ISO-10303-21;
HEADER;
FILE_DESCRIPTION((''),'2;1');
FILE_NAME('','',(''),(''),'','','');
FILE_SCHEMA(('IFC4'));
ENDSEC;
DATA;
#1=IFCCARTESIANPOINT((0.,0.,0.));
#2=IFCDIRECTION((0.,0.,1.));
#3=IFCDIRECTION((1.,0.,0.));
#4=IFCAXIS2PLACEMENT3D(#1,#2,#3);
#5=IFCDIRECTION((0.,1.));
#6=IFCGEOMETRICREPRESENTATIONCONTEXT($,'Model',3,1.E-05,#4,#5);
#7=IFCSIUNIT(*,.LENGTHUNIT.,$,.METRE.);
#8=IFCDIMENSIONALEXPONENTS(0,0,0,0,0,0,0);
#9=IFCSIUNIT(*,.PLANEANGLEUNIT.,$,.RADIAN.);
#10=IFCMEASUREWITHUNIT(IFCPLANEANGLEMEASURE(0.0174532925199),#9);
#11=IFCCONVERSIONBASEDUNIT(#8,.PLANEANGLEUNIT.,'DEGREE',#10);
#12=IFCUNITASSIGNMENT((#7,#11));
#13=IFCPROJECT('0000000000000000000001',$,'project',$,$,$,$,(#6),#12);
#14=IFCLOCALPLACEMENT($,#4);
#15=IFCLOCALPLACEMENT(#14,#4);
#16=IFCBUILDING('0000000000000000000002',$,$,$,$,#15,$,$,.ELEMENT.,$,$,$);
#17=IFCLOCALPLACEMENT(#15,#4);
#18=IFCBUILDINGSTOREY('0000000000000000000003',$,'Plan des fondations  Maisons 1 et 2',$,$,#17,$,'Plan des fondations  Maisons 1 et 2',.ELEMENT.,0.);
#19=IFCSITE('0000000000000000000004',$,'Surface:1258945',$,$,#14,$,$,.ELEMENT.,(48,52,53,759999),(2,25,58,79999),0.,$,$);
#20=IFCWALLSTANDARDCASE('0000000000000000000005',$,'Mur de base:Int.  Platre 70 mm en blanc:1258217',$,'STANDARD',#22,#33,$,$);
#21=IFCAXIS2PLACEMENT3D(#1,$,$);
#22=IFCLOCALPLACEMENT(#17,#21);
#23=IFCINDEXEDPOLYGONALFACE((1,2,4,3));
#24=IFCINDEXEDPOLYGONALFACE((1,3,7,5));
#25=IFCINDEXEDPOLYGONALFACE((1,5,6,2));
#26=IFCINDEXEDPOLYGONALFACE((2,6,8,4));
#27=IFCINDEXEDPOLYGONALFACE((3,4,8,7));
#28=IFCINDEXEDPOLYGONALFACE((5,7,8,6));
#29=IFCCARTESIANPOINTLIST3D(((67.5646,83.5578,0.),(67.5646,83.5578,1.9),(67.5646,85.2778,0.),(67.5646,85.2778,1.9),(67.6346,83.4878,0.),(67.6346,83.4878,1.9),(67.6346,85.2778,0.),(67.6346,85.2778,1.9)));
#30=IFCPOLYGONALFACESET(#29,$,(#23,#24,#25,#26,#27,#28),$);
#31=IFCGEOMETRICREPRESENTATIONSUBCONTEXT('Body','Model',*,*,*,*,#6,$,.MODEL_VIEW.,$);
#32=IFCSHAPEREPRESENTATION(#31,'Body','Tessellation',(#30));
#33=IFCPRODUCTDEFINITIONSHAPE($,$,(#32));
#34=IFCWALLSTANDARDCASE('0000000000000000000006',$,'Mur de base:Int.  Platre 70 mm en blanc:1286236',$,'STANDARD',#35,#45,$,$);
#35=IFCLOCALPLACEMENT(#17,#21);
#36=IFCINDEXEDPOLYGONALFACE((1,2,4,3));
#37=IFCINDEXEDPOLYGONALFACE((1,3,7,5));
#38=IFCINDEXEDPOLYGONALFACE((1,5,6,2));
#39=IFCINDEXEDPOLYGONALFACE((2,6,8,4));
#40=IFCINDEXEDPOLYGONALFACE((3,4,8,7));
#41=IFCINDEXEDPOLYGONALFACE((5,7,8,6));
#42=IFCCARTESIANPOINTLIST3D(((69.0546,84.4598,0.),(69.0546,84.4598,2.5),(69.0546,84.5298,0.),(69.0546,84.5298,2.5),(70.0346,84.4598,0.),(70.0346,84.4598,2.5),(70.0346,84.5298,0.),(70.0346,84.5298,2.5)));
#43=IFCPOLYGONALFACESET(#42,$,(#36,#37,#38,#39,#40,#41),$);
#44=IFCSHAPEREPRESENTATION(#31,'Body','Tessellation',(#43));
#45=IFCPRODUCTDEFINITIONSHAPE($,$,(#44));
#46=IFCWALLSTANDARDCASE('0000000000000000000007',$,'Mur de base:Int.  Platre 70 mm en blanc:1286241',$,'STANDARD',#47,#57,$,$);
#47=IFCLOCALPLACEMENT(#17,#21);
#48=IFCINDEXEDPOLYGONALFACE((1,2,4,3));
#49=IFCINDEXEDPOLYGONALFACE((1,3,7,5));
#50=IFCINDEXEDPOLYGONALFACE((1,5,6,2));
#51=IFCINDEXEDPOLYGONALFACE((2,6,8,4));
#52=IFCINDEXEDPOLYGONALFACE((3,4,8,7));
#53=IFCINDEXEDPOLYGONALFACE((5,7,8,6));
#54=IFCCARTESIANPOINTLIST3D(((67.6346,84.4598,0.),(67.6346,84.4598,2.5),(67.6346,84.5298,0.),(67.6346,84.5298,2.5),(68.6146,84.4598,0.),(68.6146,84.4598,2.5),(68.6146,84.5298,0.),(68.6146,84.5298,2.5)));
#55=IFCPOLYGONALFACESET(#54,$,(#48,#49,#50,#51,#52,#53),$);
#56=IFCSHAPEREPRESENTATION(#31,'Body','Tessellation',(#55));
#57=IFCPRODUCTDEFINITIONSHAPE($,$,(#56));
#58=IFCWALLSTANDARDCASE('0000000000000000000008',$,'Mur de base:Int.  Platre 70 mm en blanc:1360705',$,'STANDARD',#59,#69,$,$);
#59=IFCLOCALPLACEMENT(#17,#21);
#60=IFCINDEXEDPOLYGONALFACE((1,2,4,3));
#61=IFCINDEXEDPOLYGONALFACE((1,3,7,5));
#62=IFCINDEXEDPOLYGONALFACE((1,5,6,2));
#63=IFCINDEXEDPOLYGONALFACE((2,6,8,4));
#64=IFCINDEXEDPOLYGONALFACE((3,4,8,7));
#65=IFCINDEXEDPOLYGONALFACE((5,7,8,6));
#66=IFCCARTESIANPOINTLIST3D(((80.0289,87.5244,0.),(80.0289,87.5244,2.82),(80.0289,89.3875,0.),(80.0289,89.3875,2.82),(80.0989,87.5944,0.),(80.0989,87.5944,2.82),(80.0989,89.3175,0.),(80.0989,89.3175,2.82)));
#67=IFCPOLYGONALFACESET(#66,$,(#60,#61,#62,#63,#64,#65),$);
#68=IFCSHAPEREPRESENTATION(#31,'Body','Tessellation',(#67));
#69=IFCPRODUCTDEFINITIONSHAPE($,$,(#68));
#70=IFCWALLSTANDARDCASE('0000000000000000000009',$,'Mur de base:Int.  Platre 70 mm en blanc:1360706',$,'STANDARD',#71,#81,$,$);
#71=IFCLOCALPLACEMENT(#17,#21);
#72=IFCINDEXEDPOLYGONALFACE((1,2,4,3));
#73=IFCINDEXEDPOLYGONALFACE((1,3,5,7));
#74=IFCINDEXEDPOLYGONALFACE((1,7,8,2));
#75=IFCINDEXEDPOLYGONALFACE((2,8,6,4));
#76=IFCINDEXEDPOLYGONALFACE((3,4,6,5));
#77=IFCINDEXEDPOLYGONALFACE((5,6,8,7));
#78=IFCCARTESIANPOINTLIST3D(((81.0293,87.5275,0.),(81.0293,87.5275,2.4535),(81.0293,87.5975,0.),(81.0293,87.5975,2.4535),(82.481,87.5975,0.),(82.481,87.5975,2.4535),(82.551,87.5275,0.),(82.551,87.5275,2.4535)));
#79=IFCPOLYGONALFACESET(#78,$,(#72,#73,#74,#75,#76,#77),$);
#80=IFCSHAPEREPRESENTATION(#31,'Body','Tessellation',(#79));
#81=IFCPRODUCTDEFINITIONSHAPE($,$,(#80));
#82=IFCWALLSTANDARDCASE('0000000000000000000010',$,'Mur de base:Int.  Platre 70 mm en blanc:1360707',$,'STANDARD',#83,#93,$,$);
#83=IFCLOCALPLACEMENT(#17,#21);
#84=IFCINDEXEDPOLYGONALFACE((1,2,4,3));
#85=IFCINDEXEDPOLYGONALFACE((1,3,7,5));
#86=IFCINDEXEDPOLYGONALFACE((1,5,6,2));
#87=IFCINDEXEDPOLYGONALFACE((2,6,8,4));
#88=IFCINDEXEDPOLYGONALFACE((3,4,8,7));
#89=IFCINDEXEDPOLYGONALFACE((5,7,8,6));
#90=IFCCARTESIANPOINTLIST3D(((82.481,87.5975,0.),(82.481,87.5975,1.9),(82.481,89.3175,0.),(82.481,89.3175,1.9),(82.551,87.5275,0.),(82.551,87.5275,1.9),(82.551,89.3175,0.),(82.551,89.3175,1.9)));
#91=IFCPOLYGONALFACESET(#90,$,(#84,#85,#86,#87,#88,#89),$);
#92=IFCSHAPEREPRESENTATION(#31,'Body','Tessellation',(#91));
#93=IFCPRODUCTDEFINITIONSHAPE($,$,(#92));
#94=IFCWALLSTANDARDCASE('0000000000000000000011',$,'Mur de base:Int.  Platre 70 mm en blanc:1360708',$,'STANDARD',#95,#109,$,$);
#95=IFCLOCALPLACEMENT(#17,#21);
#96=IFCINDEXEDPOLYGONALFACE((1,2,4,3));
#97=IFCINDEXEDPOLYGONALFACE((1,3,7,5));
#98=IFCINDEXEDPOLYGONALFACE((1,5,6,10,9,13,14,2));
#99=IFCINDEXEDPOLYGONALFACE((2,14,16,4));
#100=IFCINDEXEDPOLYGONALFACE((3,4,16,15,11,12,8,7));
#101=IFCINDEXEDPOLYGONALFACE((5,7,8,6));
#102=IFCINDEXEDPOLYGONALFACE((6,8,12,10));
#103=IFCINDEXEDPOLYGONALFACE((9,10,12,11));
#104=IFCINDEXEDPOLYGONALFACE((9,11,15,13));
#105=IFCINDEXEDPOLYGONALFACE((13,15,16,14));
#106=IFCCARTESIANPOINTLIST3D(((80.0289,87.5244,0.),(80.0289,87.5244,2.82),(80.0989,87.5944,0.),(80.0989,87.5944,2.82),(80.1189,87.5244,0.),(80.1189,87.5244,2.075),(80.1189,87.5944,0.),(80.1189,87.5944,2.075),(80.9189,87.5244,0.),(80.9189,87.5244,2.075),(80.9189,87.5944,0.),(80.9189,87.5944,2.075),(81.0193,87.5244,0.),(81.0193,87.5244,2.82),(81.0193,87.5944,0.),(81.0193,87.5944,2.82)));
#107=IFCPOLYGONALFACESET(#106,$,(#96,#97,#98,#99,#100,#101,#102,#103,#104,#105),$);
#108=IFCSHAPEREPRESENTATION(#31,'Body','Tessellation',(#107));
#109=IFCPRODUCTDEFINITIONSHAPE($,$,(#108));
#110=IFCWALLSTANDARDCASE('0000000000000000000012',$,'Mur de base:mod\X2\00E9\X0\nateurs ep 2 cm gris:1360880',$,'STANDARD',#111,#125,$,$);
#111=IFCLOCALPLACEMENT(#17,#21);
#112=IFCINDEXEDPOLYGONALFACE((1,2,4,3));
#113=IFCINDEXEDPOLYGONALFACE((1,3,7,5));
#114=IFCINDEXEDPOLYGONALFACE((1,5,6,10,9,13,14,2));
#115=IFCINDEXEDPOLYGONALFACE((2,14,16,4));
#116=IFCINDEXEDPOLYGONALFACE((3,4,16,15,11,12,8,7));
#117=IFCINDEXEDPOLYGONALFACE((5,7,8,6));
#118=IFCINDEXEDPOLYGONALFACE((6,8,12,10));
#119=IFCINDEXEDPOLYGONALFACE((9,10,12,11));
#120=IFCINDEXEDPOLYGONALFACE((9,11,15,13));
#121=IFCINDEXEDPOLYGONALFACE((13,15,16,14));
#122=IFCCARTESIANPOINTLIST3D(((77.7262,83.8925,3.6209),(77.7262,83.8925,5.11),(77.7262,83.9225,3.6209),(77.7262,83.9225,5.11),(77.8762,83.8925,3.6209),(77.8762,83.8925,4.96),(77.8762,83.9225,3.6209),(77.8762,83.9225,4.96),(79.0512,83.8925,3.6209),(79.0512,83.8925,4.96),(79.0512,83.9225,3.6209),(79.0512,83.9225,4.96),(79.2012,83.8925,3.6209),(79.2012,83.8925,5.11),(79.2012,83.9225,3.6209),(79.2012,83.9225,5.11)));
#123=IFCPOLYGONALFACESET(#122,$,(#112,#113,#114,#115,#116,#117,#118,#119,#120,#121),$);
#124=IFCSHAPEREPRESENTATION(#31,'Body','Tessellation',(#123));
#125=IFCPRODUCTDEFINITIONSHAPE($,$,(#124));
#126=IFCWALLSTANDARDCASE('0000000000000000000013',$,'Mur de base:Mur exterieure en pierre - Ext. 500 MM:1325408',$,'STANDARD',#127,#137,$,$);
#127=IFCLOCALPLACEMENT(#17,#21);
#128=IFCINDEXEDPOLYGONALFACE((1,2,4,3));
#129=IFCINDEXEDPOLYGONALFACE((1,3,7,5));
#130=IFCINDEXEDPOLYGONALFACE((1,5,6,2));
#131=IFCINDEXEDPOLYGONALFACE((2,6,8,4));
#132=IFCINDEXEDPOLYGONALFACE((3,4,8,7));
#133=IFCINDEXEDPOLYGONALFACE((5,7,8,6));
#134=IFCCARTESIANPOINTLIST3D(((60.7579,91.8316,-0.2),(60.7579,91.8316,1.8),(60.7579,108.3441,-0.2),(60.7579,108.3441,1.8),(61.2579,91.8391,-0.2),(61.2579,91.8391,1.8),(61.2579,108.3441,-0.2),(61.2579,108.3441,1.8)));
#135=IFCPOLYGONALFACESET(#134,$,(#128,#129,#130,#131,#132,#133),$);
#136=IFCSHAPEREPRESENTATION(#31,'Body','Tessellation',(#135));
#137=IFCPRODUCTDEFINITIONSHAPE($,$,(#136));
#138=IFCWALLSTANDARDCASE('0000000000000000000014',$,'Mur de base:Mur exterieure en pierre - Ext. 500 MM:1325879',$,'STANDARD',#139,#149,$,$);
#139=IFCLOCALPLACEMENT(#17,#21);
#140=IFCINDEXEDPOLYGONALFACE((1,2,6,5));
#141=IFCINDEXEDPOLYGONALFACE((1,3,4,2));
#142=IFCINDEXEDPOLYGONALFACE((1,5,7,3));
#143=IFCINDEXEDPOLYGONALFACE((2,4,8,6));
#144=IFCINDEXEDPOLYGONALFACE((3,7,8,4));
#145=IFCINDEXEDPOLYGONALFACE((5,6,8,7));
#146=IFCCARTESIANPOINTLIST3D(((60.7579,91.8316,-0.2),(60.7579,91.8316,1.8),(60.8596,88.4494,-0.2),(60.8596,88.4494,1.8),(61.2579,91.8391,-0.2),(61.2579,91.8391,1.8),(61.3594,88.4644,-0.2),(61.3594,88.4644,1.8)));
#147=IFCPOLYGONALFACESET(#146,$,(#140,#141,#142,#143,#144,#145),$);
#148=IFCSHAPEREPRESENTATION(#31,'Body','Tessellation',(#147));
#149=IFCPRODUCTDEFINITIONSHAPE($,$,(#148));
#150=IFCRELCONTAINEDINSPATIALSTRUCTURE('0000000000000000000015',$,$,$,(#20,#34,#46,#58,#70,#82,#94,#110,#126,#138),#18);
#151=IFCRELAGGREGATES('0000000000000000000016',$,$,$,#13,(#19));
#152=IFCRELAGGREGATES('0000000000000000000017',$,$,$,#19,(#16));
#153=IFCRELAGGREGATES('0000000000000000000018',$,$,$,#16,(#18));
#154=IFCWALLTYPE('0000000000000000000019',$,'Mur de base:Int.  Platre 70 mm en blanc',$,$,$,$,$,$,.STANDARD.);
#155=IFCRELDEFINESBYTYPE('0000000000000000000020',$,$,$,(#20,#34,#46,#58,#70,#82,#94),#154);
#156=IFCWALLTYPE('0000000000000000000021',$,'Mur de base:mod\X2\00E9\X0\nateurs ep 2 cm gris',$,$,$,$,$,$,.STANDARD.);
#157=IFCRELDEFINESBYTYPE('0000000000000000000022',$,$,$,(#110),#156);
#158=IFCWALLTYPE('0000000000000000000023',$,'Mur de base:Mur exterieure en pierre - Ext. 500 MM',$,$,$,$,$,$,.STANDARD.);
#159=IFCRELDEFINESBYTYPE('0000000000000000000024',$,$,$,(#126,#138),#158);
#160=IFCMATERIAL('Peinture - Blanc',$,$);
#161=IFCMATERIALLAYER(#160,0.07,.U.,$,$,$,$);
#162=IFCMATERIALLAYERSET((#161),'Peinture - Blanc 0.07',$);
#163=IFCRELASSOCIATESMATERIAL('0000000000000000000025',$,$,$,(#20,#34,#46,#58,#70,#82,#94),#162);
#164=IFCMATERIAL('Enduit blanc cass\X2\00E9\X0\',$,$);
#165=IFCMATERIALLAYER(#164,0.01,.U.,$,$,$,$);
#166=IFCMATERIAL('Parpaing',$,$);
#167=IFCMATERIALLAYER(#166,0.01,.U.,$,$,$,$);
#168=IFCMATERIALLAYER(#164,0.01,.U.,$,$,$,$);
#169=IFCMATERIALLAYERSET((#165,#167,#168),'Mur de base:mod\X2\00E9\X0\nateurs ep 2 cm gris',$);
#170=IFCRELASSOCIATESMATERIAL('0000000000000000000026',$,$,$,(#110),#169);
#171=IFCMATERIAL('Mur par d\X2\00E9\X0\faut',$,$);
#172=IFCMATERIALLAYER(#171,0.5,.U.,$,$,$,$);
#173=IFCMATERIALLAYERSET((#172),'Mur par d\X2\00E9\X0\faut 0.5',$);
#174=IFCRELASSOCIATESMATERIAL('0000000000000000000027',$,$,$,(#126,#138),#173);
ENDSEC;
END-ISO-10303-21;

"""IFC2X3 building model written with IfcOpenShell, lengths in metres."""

from ifc_helpers import new_model, entity, si_unit, converted_unit, direction, frame, origin_with_axes, origin_2d_with_axis, place, context, subcontext, project, spatial, polyline, rectangle, outline, extrude, clip, halfspace, material, layer, layer_set, layer_usage, type_object, element, save


model = new_model("IFC2X3")

# Units and contexts
model_context = context("Model", 3, precision=1e-05, world=origin_with_axes(), true_north=direction((0.0, 1.0)))
body_context = subcontext(model_context, "Body", "Model", "MODEL_VIEW")
ifc_project = project(units=[si_unit("LENGTHUNIT", "METRE"), converted_unit("PLANEANGLEUNIT", "DEGREE", entity("IfcPlaneAngleMeasure", 0.0174532925199), si_unit("PLANEANGLEUNIT", "RADIAN"), dimensions=[0, 0, 0, 0, 0, 0, 0])], contexts=[model_context])

# Site, building, storey
site_placement = place(None, origin_with_axes())
site = spatial("IfcSite", under=ifc_project, at=site_placement, Name="Surface:1258945", CompositionType="ELEMENT", RefLatitude=(48, 52, 53, 759999), RefLongitude=(2, 25, 58, 79999), RefElevation=0.0)
building_placement = place(site_placement, origin_with_axes())
building = spatial("IfcBuilding", under=site, at=building_placement, CompositionType="ELEMENT")
storey_placement = place(building_placement, origin_with_axes())
storey = spatial("IfcBuildingStorey", under=building, at=storey_placement, Name="Plan des fondations  Maisons 1 et 2", LongName="Plan des fondations  Maisons 1 et 2", CompositionType="ELEMENT", Elevation=0.0)

# Shared definitions
ifc_material_1 = material(Name="Parpaing")
ifc_material_2 = material(Name="Peinture - Blanc")

# Walls
ifc_layer_1 = layer(ifc_material_2, 0.07, ventilated="UNKNOWN")
ifc_layer_set_1 = layer_set([ifc_layer_1], Name="Peinture - Blanc 0.07")
wall_type_1 = type_object("IfcWallType", Name="Mur de base:Int.  Platre 70 mm en blanc", PredefinedType="STANDARD")
ifc_layer_usage_1 = layer_usage(ifc_layer_set_1, "AXIS2", "POSITIVE", -0.035)
wall_1_placement = place(storey_placement, frame((67.5996, 83.5228, 0.0), z_axis=(0.0, 0.0, 1.0), x_axis=(0.0, 1.0, 0.0)))
element("IfcWallStandardCase", 1, at=wall_1_placement, inside=storey, type_object=wall_type_1, material=ifc_layer_usage_1, Name="Mur de base:Int.  Platre 70 mm en blanc:1258217", ObjectType="STANDARD", context=body_context, shape_type="SweptSolid", body=[
    extrude(outline(polyline([(-0.035, -0.035), (1.755, -0.035), (1.755, 0.035), (0.035, 0.035), (-0.035, -0.035)])), origin_with_axes(), (0.0, 0.0, 1.0), 1.9),
])
ifc_layer_usage_2 = layer_usage(ifc_layer_set_1, "AXIS2", "POSITIVE", -0.035)
wall_2_placement = place(storey_placement, frame((70.0696, 84.4948, 0.0), z_axis=(0.0, 0.0, 1.0), x_axis=(-1.0, 0.0, 0.0)))
element("IfcWallStandardCase", 2, at=wall_2_placement, inside=storey, type_object=wall_type_1, material=ifc_layer_usage_2, Name="Mur de base:Int.  Platre 70 mm en blanc:1286236", ObjectType="STANDARD", context=body_context, shape_type="SweptSolid", body=[
    extrude(outline(polyline([(0.035, -0.035), (1.015, -0.035), (1.015, 0.035), (0.035, 0.035), (0.035, -0.035)])), origin_with_axes(), (0.0, 0.0, 1.0), 2.5),
])
ifc_layer_usage_3 = layer_usage(ifc_layer_set_1, "AXIS2", "POSITIVE", -0.035)
wall_3_placement = place(storey_placement, frame((67.5996, 84.4948, 0.0), z_axis=(0.0, 0.0, 1.0), x_axis=(1.0, 0.0, 0.0)))
element("IfcWallStandardCase", 3, at=wall_3_placement, inside=storey, type_object=wall_type_1, material=ifc_layer_usage_3, Name="Mur de base:Int.  Platre 70 mm en blanc:1286241", ObjectType="STANDARD", context=body_context, shape_type="SweptSolid", body=[
    extrude(outline(polyline([(0.035, -0.035), (1.015, -0.035), (1.015, 0.035), (0.035, 0.035), (0.035, -0.035)])), origin_with_axes(), (0.0, 0.0, 1.0), 2.5),
])
ifc_layer_usage_4 = layer_usage(ifc_layer_set_1, "AXIS2", "POSITIVE", -0.035)
wall_4_placement = place(storey_placement, frame((80.0639, 87.5594, 0.0), z_axis=(0.0, 0.0, 1.0), x_axis=(0.0, 1.0, 0.0)))
element("IfcWallStandardCase", 4, at=wall_4_placement, inside=storey, type_object=wall_type_1, material=ifc_layer_usage_4, Name="Mur de base:Int.  Platre 70 mm en blanc:1360705", ObjectType="STANDARD", context=body_context, shape_type="SweptSolid", body=[
    extrude(outline(polyline([(0.035, -0.035), (1.7581, -0.035), (1.8281, 0.035), (-0.035, 0.035), (0.035, -0.035)])), origin_with_axes(), (0.0, 0.0, 1.0), 2.82),
])
ifc_layer_usage_5 = layer_usage(ifc_layer_set_1, "AXIS2", "POSITIVE", -0.035)
wall_5_placement = place(storey_placement, frame((82.516, 87.5625, 0.0), z_axis=(0.0, 0.0, 1.0), x_axis=(-1.0, 0.0, 0.0)))
element("IfcWallStandardCase", 5, at=wall_5_placement, inside=storey, type_object=wall_type_1, material=ifc_layer_usage_5, Name="Mur de base:Int.  Platre 70 mm en blanc:1360706", ObjectType="STANDARD", context=body_context, shape_type="SweptSolid", body=[
    extrude(outline(polyline([(0.035, -0.035), (1.4867, -0.035), (1.4867, 0.035), (-0.035, 0.035), (0.035, -0.035)])), origin_with_axes(), (0.0, 0.0, 1.0), 2.4535),
])
ifc_layer_usage_6 = layer_usage(ifc_layer_set_1, "AXIS2", "POSITIVE", -0.035)
wall_6_placement = place(storey_placement, frame((82.516, 87.5625, 0.0), z_axis=(0.0, 0.0, 1.0), x_axis=(0.0, 1.0, 0.0)))
element("IfcWallStandardCase", 6, at=wall_6_placement, inside=storey, type_object=wall_type_1, material=ifc_layer_usage_6, Name="Mur de base:Int.  Platre 70 mm en blanc:1360707", ObjectType="STANDARD", context=body_context, shape_type="SweptSolid", body=[
    extrude(outline(polyline([(-0.035, -0.035), (1.755, -0.035), (1.755, 0.035), (0.035, 0.035), (-0.035, -0.035)])), origin_with_axes(), (0.0, 0.0, 1.0), 1.9),
])

# Walls, openings
ifc_layer_usage_7 = layer_usage(ifc_layer_set_1, "AXIS2", "POSITIVE", -0.035)
wall_7_placement = place(storey_placement, frame((81.0193, 87.5594, 0.0), z_axis=(0.0, 0.0, 1.0), x_axis=(-1.0, 0.0, 0.0)))
wall_7 = element("IfcWallStandardCase", 7, at=wall_7_placement, inside=storey, type_object=wall_type_1, material=ifc_layer_usage_7, Name="Mur de base:Int.  Platre 70 mm en blanc:1360708", ObjectType="STANDARD", context=body_context, shape_type="SweptSolid", body=[
    extrude(outline(polyline([(0.0, -0.035), (0.9204, -0.035), (0.9904, 0.035), (0.0, 0.035), (0.0, -0.035)])), origin_with_axes(), (0.0, 0.0, 1.0), 2.82),
])
opening_1_placement = place(wall_7_placement, frame((0.5004, 0.0, 0.0), z_axis=(0.0, 0.0, 1.0), x_axis=(1.0, 0.0, 0.0)))
element("IfcOpeningElement", 8, at=opening_1_placement, cuts=wall_7, context=body_context, shape_type="SweptSolid", body=[
    extrude(outline(polyline([(0.4, 0.0), (0.4, 2.075), (-0.4, 2.075), (-0.4, 0.0), (0.4, 0.0)])), frame((0.0, -0.035, 0.0), z_axis=(0.0, 1.0, 0.0), x_axis=(-1.0, 0.0, 0.0)), (0.0, 0.0, 1.0), 0.07),
])
ifc_material_3 = material(Name="Enduit blanc cassé")
ifc_layer_2 = layer(ifc_material_3, 0.01, ventilated="UNKNOWN")
ifc_layer_3 = layer(ifc_material_1, 0.01, ventilated="UNKNOWN")
ifc_layer_4 = layer(ifc_material_3, 0.01, ventilated="UNKNOWN")
ifc_layer_set_2 = layer_set([ifc_layer_2, ifc_layer_3, ifc_layer_4], Name="Mur de base:modénateurs ep 2 cm gris")
wall_type_2 = type_object("IfcWallType", Name="Mur de base:modénateurs ep 2 cm gris", PredefinedType="STANDARD")
ifc_layer_usage_8 = layer_usage(ifc_layer_set_2, "AXIS2", "POSITIVE", -0.015)
wall_8_placement = place(storey_placement, frame((79.2012, 83.9075, 3.6209), z_axis=(0.0, 0.0, 1.0), x_axis=(-1.0, 0.0, 0.0)))
wall_8 = element("IfcWallStandardCase", 9, at=wall_8_placement, inside=storey, type_object=wall_type_2, material=ifc_layer_usage_8, Name="Mur de base:modénateurs ep 2 cm gris:1360880", ObjectType="STANDARD", context=body_context, shape_type="Clipping", body=[
    clip(extrude(outline(polyline([(0.0, -0.015), (1.475, -0.015), (1.475, 0.015), (0.0, 0.015), (0.0, -0.015)])), origin_with_axes(), (0.0, 0.0, 1.0), 1.4891), halfspace(frame((0.0, 0.0, 0.0), z_axis=(0.0, 0.0, 1.0), x_axis=(0.0, -1.0, 0.0)), True)),
])
opening_2_placement = place(wall_8_placement, frame((79.2012, 83.9075, -3.6209), z_axis=(0.0, 0.0, 1.0), x_axis=(-1.0, 0.0, 0.0)))
element("IfcOpeningElement", 10, at=opening_2_placement, cuts=wall_8, context=body_context, shape_type="SweptSolid", body=[
    extrude(rectangle(XDim=1.3391, YDim=1.175, at=origin_2d_with_axis()), frame((78.4637, 83.8925, 4.2904), z_axis=(0.0, 1.0, 0.0), x_axis=(0.0, 0.0, 1.0)), (0.0, 0.0, 1.0), 0.03),
])

# Walls
ifc_material_4 = material(Name="Mur par défaut")
ifc_layer_5 = layer(ifc_material_4, 0.5, ventilated="UNKNOWN")
ifc_layer_set_3 = layer_set([ifc_layer_5], Name="Mur par défaut 0.5")
ifc_layer_usage_9 = layer_usage(ifc_layer_set_3, "AXIS2", "POSITIVE", -0.25)
wall_type_3 = type_object("IfcWallType", Name="Mur de base:Mur exterieure en pierre - Ext. 500 MM", PredefinedType="STANDARD")
wall_9_placement = place(storey_placement, frame((61.0079, 108.3441, -0.2), z_axis=(0.0, 0.0, 1.0), x_axis=(0.0, -1.0, 0.0)))
element("IfcWallStandardCase", 11, at=wall_9_placement, inside=storey, type_object=wall_type_3, material=ifc_layer_usage_9, Name="Mur de base:Mur exterieure en pierre - Ext. 500 MM:1325408", ObjectType="STANDARD", context=body_context, shape_type="SweptSolid", body=[
    extrude(outline(polyline([(0.0, -0.25), (16.5124, -0.25), (16.5049, 0.25), (0.0, 0.25), (0.0, -0.25)])), origin_with_axes(), (0.0, 0.0, 1.0), 2.0),
])
ifc_layer_usage_10 = layer_usage(ifc_layer_set_3, "AXIS2", "POSITIVE", -0.25)
wall_10_placement = place(storey_placement, frame((61.0079, 91.8354, -0.2), z_axis=(0.0, 0.0, 1.0), x_axis=(0.030044, -0.999549, 0.0)))
element("IfcWallStandardCase", 12, at=wall_10_placement, inside=storey, type_object=wall_type_3, material=ifc_layer_usage_10, Name="Mur de base:Mur exterieure en pierre - Ext. 500 MM:1325879", ObjectType="STANDARD", context=body_context, shape_type="SweptSolid", body=[
    extrude(outline(polyline([(-0.0038, -0.25), (3.38, -0.25), (3.38, 0.25), (0.0038, 0.25), (-0.0038, -0.25)])), origin_with_axes(), (0.0, 0.0, 1.0), 2.0),
])

save(model, "model.ifc")
